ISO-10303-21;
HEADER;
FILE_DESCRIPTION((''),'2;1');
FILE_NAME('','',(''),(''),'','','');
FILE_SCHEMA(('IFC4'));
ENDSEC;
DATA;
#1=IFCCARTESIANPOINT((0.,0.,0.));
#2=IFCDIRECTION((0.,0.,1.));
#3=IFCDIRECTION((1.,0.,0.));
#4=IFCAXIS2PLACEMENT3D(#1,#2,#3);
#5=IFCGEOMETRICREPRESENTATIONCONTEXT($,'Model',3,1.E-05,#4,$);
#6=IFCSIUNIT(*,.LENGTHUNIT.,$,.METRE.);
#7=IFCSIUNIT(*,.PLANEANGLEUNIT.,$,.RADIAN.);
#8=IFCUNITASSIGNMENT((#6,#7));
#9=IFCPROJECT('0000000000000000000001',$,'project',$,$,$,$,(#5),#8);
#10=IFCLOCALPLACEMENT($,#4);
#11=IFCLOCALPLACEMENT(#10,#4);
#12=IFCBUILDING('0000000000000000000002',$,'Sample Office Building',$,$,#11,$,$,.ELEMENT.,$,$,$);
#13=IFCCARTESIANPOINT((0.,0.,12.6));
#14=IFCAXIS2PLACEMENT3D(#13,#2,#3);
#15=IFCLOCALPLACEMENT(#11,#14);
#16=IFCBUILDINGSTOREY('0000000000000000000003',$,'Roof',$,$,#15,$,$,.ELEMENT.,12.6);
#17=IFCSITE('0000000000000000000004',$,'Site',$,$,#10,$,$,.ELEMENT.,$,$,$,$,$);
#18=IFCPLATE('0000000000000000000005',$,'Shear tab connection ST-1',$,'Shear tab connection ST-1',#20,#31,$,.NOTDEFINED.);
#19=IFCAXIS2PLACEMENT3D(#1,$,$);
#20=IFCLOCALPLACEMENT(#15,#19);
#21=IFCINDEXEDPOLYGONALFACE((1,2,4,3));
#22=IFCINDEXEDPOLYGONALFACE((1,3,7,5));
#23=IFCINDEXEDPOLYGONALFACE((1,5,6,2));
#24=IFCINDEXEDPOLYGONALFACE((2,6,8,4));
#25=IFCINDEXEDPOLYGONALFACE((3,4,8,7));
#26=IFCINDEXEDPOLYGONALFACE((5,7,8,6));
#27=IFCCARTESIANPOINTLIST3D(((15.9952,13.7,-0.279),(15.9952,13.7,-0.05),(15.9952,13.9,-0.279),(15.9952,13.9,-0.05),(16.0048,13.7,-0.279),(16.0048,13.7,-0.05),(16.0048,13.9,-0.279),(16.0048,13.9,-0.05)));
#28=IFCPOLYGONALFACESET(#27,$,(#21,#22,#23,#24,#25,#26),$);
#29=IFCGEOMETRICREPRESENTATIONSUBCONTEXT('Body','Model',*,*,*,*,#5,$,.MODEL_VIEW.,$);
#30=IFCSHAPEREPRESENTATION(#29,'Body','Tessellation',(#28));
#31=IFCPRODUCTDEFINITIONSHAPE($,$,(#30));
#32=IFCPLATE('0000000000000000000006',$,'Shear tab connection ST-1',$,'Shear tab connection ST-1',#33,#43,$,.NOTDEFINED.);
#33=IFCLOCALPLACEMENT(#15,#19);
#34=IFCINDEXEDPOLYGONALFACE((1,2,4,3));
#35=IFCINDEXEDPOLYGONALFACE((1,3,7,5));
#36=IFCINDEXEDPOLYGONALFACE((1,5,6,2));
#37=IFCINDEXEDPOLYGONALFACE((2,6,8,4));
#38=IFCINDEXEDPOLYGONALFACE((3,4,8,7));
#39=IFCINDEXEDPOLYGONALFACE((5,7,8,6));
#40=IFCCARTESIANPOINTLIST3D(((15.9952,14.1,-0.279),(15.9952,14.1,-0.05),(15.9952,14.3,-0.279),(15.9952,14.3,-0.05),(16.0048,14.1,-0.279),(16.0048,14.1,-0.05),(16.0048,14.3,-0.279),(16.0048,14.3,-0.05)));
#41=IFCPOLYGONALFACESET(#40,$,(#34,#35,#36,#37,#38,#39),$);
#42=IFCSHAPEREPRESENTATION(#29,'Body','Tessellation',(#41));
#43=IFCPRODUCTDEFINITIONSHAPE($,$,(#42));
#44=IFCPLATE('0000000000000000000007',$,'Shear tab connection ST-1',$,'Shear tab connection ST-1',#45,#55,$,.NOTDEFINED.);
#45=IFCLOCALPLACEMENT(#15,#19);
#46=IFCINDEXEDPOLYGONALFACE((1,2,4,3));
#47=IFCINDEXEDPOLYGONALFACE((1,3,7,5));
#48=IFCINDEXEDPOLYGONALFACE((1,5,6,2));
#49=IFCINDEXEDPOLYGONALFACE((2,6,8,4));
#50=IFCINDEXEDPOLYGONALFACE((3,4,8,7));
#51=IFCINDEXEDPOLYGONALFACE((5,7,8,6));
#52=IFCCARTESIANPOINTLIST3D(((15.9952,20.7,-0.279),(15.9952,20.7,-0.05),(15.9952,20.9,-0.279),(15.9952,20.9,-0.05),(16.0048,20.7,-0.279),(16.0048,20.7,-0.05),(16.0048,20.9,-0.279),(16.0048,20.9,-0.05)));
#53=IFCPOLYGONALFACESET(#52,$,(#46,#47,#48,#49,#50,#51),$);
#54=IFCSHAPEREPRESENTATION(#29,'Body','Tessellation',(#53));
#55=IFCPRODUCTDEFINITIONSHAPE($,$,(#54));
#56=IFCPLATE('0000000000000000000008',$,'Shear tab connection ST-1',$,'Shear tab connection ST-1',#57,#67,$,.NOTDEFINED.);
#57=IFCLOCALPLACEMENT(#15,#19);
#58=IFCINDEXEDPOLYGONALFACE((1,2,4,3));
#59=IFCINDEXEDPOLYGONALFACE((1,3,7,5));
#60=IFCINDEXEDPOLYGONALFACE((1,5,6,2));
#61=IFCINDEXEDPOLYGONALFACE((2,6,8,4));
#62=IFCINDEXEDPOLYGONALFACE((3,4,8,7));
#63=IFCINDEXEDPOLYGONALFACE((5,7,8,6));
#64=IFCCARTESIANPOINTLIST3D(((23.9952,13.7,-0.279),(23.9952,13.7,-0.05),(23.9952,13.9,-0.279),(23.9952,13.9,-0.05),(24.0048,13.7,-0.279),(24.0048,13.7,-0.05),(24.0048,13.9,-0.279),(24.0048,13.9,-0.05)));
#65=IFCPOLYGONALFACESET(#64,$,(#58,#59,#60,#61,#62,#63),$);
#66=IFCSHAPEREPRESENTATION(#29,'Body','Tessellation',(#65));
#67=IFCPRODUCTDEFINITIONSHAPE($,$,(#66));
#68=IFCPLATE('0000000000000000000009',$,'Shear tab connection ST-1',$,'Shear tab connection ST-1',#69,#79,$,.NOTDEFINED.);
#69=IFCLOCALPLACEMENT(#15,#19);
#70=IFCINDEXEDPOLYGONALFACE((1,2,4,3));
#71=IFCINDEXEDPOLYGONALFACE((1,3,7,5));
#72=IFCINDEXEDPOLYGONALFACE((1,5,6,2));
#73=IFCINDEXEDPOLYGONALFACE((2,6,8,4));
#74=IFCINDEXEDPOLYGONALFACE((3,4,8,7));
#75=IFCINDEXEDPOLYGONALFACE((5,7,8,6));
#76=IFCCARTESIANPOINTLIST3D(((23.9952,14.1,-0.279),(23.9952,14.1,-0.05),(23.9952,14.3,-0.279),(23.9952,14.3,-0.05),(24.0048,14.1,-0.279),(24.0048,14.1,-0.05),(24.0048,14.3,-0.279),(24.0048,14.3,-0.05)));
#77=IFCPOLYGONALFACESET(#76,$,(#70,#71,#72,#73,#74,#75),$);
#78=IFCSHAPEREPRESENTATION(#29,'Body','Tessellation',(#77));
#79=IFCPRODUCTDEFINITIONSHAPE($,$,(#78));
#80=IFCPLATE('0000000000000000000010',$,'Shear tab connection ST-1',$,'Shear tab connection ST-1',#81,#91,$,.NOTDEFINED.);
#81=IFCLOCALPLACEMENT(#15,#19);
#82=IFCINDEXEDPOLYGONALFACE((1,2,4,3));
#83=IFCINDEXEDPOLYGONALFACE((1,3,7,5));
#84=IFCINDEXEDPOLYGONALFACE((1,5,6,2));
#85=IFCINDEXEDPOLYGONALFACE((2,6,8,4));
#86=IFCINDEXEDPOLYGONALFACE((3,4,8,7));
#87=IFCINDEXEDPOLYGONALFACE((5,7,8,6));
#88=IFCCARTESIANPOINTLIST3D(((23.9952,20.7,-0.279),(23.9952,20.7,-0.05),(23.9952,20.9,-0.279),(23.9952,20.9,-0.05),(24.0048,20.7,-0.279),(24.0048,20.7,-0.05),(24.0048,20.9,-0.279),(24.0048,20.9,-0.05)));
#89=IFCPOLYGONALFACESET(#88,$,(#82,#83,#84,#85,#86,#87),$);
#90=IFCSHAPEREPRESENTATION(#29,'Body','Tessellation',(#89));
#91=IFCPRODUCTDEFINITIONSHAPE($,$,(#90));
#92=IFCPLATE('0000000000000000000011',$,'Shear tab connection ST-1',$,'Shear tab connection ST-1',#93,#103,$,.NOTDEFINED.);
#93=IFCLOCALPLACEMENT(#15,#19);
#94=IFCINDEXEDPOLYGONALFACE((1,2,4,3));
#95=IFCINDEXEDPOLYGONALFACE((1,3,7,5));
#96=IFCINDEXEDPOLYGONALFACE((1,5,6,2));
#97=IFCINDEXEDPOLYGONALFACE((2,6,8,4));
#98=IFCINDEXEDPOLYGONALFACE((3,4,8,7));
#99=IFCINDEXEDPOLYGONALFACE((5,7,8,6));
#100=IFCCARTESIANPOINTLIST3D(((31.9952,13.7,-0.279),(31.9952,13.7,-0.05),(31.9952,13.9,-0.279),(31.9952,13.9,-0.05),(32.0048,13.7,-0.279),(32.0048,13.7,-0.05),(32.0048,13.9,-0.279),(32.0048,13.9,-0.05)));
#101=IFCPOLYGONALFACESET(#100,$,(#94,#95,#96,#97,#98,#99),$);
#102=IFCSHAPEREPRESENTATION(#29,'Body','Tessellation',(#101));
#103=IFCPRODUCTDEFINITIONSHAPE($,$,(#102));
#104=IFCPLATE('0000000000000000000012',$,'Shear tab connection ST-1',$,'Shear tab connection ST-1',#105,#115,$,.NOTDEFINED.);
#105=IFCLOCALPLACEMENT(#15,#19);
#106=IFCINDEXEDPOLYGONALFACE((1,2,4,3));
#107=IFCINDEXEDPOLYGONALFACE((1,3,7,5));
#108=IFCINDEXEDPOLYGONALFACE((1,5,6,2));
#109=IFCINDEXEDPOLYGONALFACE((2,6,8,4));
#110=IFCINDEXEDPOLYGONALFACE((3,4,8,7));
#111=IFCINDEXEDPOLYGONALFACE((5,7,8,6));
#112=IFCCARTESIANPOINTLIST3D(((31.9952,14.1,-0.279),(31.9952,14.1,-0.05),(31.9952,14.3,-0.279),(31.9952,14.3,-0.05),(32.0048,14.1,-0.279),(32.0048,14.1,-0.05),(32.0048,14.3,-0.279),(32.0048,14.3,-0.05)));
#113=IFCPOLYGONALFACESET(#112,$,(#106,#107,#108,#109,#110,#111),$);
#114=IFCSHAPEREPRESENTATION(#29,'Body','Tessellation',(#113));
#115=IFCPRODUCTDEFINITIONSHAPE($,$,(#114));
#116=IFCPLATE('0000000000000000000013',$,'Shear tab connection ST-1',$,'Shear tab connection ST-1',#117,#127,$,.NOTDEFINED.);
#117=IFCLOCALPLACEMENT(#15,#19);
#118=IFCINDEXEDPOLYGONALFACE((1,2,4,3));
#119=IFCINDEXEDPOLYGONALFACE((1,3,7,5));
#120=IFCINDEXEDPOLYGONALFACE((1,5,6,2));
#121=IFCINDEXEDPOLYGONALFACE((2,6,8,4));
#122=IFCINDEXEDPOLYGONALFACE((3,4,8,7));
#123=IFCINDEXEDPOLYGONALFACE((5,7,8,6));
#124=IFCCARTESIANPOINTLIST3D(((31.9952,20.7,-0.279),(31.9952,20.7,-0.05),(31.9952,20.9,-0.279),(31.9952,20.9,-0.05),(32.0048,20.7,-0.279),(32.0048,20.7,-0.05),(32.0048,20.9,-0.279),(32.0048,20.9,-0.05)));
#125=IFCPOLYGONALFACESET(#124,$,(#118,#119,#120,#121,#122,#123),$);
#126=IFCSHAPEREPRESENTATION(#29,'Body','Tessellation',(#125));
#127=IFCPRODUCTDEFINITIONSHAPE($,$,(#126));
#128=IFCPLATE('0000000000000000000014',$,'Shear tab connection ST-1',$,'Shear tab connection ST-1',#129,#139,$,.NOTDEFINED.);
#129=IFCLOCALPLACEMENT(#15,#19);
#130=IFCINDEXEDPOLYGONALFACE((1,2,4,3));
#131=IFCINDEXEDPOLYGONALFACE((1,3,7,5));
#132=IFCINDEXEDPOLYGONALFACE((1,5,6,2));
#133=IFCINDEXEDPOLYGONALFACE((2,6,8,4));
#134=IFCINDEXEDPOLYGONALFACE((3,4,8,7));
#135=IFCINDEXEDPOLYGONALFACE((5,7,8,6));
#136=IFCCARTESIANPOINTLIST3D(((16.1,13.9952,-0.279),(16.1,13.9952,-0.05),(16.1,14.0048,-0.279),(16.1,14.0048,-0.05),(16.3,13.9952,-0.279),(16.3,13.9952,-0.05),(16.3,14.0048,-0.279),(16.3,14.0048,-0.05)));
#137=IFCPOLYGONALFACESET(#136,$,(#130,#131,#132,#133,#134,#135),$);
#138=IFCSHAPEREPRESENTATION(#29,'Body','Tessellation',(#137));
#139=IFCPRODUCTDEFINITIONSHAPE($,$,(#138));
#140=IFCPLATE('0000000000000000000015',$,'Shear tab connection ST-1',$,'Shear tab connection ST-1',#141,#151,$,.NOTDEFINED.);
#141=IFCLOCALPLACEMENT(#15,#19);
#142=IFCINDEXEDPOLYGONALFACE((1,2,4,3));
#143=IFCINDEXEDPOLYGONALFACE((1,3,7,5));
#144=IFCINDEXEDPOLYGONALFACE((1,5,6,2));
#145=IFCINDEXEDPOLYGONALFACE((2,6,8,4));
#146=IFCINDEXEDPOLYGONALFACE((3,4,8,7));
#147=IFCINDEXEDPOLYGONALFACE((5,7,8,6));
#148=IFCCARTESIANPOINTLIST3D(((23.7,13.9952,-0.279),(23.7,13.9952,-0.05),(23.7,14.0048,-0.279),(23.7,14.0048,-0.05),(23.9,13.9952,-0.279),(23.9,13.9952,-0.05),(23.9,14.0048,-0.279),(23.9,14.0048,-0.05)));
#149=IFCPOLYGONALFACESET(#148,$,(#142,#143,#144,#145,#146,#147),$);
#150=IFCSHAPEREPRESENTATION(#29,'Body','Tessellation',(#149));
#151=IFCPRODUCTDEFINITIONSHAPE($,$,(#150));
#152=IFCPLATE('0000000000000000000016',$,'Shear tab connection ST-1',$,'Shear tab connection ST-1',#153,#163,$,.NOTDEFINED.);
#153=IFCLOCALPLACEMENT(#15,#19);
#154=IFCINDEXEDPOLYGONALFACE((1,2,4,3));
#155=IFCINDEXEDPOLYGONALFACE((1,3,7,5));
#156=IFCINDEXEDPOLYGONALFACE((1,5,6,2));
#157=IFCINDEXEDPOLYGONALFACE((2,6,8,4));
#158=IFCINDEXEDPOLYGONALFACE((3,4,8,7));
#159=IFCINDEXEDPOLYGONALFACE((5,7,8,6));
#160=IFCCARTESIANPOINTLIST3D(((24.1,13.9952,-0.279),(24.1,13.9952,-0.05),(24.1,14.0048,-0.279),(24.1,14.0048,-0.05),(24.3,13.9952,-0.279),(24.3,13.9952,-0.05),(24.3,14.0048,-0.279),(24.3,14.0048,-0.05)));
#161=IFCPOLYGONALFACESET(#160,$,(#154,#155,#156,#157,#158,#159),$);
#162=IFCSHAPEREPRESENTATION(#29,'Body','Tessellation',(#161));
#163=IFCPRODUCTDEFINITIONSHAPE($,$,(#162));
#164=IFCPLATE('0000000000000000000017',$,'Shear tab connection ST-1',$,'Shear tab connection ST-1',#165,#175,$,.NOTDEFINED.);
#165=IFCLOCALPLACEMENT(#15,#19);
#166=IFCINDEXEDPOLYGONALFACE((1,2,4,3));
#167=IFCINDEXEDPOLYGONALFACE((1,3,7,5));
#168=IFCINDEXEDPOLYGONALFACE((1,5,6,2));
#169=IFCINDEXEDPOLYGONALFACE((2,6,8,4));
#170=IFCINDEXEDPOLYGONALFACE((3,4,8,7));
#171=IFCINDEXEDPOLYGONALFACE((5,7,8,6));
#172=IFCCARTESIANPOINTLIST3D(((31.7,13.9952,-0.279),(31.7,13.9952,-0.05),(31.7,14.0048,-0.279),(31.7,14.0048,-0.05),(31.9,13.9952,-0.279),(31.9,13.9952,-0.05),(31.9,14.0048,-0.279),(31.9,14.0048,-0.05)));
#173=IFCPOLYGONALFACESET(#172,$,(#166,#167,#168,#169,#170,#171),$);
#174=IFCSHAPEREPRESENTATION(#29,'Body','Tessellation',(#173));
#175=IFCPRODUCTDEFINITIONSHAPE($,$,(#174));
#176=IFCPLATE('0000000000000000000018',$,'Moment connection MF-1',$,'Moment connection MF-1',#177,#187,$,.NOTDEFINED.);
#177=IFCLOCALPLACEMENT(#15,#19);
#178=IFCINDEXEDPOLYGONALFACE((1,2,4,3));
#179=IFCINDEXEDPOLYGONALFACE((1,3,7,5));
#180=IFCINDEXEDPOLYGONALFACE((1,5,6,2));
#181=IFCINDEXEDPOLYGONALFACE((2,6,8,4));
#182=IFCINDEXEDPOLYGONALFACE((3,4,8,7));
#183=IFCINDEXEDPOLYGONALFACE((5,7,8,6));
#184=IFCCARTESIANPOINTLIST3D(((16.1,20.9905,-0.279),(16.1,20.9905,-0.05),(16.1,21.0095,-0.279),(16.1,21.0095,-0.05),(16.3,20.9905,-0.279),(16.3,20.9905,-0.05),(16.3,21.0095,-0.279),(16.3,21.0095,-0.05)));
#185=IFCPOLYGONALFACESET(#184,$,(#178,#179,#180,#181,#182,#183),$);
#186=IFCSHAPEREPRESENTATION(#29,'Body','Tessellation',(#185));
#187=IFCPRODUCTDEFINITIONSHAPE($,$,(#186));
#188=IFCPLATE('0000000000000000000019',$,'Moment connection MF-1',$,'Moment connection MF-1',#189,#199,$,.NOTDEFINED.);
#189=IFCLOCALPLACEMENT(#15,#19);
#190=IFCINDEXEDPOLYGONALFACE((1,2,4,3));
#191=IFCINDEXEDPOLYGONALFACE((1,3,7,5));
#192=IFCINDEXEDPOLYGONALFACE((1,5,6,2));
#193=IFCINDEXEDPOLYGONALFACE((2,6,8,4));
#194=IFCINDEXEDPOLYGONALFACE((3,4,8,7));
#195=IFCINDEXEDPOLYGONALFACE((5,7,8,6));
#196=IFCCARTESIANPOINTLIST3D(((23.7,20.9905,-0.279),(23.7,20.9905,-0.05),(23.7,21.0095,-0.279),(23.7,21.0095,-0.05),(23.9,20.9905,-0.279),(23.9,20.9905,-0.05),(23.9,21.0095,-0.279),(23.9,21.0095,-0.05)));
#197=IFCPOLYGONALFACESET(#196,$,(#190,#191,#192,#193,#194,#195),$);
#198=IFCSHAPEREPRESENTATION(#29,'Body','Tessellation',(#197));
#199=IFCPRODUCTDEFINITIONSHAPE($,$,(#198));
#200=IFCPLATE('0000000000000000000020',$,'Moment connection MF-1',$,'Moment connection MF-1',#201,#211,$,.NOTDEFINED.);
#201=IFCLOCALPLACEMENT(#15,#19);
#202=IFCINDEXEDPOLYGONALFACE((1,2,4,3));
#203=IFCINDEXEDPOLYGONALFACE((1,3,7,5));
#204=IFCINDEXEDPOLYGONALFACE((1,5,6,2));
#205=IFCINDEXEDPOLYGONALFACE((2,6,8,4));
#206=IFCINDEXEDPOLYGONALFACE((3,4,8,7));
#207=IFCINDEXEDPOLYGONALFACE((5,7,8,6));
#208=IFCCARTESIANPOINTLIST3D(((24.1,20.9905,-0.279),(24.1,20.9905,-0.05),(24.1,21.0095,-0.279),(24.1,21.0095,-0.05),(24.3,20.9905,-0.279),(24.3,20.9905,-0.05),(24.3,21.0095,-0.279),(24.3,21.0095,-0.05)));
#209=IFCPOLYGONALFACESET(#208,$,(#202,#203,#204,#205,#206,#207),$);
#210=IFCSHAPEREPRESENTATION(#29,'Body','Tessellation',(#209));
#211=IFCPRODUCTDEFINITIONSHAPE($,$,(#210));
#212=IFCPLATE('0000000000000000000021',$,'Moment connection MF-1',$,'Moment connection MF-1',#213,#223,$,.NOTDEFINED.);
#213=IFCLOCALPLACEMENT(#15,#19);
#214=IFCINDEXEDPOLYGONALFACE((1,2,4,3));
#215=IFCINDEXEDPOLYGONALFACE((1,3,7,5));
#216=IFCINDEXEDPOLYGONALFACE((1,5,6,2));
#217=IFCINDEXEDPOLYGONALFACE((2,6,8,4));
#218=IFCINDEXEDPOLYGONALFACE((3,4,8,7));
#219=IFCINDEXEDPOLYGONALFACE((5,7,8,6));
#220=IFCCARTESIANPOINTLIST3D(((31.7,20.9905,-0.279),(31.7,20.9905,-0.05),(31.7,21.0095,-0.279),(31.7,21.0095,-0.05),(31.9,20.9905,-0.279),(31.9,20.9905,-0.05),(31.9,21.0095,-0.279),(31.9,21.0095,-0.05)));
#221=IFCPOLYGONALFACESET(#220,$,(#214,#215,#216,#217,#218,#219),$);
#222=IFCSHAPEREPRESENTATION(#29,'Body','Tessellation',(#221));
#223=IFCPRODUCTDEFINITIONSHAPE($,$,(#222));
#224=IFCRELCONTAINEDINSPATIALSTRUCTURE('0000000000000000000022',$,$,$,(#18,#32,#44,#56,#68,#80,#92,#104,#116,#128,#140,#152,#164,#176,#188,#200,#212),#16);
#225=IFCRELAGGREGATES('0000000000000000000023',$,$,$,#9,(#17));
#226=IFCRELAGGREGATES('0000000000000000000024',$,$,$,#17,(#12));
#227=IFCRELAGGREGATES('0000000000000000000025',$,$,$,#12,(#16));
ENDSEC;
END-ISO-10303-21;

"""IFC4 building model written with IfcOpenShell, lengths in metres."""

from ifc_helpers import new_model, si_unit, frame, origin_with_axes, place, context, subcontext, project, spatial, rectangle, extrude, element, save


model = new_model("IFC4")

# Units and contexts
model_context = context("Model", 3, precision=1e-05, world=origin_with_axes())
body_context = subcontext(model_context, "Body", "Model", "MODEL_VIEW")
ifc_project = project(units=[si_unit("LENGTHUNIT", "METRE"), si_unit("PLANEANGLEUNIT", "RADIAN")], contexts=[model_context])

# Site, building, storey
site_placement = place(None, origin_with_axes())
site = spatial("IfcSite", under=ifc_project, at=site_placement, Name="Site", CompositionType="ELEMENT")
building_placement = place(site_placement, origin_with_axes())
building = spatial("IfcBuilding", under=site, at=building_placement, Name="Sample Office Building", CompositionType="ELEMENT")
storey_placement = place(building_placement, frame((0.0, 0.0, 12.6), z_axis=(0.0, 0.0, 1.0), x_axis=(1.0, 0.0, 0.0)))
storey = spatial("IfcBuildingStorey", under=building, at=storey_placement, Name="Roof", CompositionType="ELEMENT", Elevation=12.6)

# Plates
for number, where, z_axis, x_axis, name in (
    (1, (16.0, 13.8, 12.321), (0.0, 0.0, 1.0), (1.0, 0.0, 0.0), "Shear tab connection ST-1"),
    (2, (16.0, 14.2, 12.321), (0.0, 0.0, 1.0), (1.0, 0.0, 0.0), "Shear tab connection ST-1"),
):
    element("IfcPlate", number, at=place(None, frame(where, z_axis=z_axis, x_axis=x_axis)), inside=storey, Name=name, ObjectType="Shear tab connection ST-1", PredefinedType="NOTDEFINED", context=body_context, shape_type="SweptSolid", body=[
        extrude(rectangle(XDim=0.0095, YDim=0.2), None, (0.0, 0.0, 1.0), 0.229),
    ])
plate_1_placement = place(None, frame((16.0, 20.8, 12.321), z_axis=(0.0, 0.0, 1.0), x_axis=(1.0, 0.0, 0.0)))
element("IfcPlate", 3, at=plate_1_placement, inside=storey, Name="Shear tab connection ST-1", ObjectType="Shear tab connection ST-1", PredefinedType="NOTDEFINED", context=body_context, shape_type="SweptSolid", body=[
    extrude(rectangle(XDim=0.0095, YDim=0.2), None, (0.0, 0.0, 1.0), 0.229),
])
for number, where, z_axis, x_axis, name in (
    (4, (24.0, 13.8, 12.321), (0.0, 0.0, 1.0), (1.0, 0.0, 0.0), "Shear tab connection ST-1"),
    (5, (24.0, 14.2, 12.321), (0.0, 0.0, 1.0), (1.0, 0.0, 0.0), "Shear tab connection ST-1"),
):
    element("IfcPlate", number, at=place(None, frame(where, z_axis=z_axis, x_axis=x_axis)), inside=storey, Name=name, ObjectType="Shear tab connection ST-1", PredefinedType="NOTDEFINED", context=body_context, shape_type="SweptSolid", body=[
        extrude(rectangle(XDim=0.0095, YDim=0.2), None, (0.0, 0.0, 1.0), 0.229),
    ])
plate_2_placement = place(None, frame((24.0, 20.8, 12.321), z_axis=(0.0, 0.0, 1.0), x_axis=(1.0, 0.0, 0.0)))
element("IfcPlate", 6, at=plate_2_placement, inside=storey, Name="Shear tab connection ST-1", ObjectType="Shear tab connection ST-1", PredefinedType="NOTDEFINED", context=body_context, shape_type="SweptSolid", body=[
    extrude(rectangle(XDim=0.0095, YDim=0.2), None, (0.0, 0.0, 1.0), 0.229),
])
for number, where, z_axis, x_axis, name in (
    (7, (32.0, 13.8, 12.321), (0.0, 0.0, 1.0), (1.0, 0.0, 0.0), "Shear tab connection ST-1"),
    (8, (32.0, 14.2, 12.321), (0.0, 0.0, 1.0), (1.0, 0.0, 0.0), "Shear tab connection ST-1"),
):
    element("IfcPlate", number, at=place(None, frame(where, z_axis=z_axis, x_axis=x_axis)), inside=storey, Name=name, ObjectType="Shear tab connection ST-1", PredefinedType="NOTDEFINED", context=body_context, shape_type="SweptSolid", body=[
        extrude(rectangle(XDim=0.0095, YDim=0.2), None, (0.0, 0.0, 1.0), 0.229),
    ])
plate_3_placement = place(None, frame((32.0, 20.8, 12.321), z_axis=(0.0, 0.0, 1.0), x_axis=(1.0, 0.0, 0.0)))
element("IfcPlate", 9, at=plate_3_placement, inside=storey, Name="Shear tab connection ST-1", ObjectType="Shear tab connection ST-1", PredefinedType="NOTDEFINED", context=body_context, shape_type="SweptSolid", body=[
    extrude(rectangle(XDim=0.0095, YDim=0.2), None, (0.0, 0.0, 1.0), 0.229),
])
for number, where, z_axis, x_axis, name in (
    (10, (16.2, 14.0, 12.321), (0.0, 0.0, 1.0), (1.0, 0.0, 0.0), "Shear tab connection ST-1"),
    (11, (23.8, 14.0, 12.321), (0.0, 0.0, 1.0), (1.0, 0.0, 0.0), "Shear tab connection ST-1"),
    (12, (24.2, 14.0, 12.321), (0.0, 0.0, 1.0), (1.0, 0.0, 0.0), "Shear tab connection ST-1"),
    (13, (31.8, 14.0, 12.321), (0.0, 0.0, 1.0), (1.0, 0.0, 0.0), "Shear tab connection ST-1"),
):
    element("IfcPlate", number, at=place(None, frame(where, z_axis=z_axis, x_axis=x_axis)), inside=storey, Name=name, ObjectType="Shear tab connection ST-1", PredefinedType="NOTDEFINED", context=body_context, shape_type="SweptSolid", body=[
        extrude(rectangle(XDim=0.2, YDim=0.0095), None, (0.0, 0.0, 1.0), 0.229),
    ])
for number, where, z_axis, x_axis, name in (
    (14, (16.2, 21.0, 12.321), (0.0, 0.0, 1.0), (1.0, 0.0, 0.0), "Moment connection MF-1"),
    (15, (23.8, 21.0, 12.321), (0.0, 0.0, 1.0), (1.0, 0.0, 0.0), "Moment connection MF-1"),
    (16, (24.2, 21.0, 12.321), (0.0, 0.0, 1.0), (1.0, 0.0, 0.0), "Moment connection MF-1"),
    (17, (31.8, 21.0, 12.321), (0.0, 0.0, 1.0), (1.0, 0.0, 0.0), "Moment connection MF-1"),
):
    element("IfcPlate", number, at=place(None, frame(where, z_axis=z_axis, x_axis=x_axis)), inside=storey, Name=name, ObjectType="Moment connection MF-1", PredefinedType="NOTDEFINED", context=body_context, shape_type="SweptSolid", body=[
        extrude(rectangle(XDim=0.2, YDim=0.019), None, (0.0, 0.0, 1.0), 0.229),
    ])

save(model, "model.ifc")
